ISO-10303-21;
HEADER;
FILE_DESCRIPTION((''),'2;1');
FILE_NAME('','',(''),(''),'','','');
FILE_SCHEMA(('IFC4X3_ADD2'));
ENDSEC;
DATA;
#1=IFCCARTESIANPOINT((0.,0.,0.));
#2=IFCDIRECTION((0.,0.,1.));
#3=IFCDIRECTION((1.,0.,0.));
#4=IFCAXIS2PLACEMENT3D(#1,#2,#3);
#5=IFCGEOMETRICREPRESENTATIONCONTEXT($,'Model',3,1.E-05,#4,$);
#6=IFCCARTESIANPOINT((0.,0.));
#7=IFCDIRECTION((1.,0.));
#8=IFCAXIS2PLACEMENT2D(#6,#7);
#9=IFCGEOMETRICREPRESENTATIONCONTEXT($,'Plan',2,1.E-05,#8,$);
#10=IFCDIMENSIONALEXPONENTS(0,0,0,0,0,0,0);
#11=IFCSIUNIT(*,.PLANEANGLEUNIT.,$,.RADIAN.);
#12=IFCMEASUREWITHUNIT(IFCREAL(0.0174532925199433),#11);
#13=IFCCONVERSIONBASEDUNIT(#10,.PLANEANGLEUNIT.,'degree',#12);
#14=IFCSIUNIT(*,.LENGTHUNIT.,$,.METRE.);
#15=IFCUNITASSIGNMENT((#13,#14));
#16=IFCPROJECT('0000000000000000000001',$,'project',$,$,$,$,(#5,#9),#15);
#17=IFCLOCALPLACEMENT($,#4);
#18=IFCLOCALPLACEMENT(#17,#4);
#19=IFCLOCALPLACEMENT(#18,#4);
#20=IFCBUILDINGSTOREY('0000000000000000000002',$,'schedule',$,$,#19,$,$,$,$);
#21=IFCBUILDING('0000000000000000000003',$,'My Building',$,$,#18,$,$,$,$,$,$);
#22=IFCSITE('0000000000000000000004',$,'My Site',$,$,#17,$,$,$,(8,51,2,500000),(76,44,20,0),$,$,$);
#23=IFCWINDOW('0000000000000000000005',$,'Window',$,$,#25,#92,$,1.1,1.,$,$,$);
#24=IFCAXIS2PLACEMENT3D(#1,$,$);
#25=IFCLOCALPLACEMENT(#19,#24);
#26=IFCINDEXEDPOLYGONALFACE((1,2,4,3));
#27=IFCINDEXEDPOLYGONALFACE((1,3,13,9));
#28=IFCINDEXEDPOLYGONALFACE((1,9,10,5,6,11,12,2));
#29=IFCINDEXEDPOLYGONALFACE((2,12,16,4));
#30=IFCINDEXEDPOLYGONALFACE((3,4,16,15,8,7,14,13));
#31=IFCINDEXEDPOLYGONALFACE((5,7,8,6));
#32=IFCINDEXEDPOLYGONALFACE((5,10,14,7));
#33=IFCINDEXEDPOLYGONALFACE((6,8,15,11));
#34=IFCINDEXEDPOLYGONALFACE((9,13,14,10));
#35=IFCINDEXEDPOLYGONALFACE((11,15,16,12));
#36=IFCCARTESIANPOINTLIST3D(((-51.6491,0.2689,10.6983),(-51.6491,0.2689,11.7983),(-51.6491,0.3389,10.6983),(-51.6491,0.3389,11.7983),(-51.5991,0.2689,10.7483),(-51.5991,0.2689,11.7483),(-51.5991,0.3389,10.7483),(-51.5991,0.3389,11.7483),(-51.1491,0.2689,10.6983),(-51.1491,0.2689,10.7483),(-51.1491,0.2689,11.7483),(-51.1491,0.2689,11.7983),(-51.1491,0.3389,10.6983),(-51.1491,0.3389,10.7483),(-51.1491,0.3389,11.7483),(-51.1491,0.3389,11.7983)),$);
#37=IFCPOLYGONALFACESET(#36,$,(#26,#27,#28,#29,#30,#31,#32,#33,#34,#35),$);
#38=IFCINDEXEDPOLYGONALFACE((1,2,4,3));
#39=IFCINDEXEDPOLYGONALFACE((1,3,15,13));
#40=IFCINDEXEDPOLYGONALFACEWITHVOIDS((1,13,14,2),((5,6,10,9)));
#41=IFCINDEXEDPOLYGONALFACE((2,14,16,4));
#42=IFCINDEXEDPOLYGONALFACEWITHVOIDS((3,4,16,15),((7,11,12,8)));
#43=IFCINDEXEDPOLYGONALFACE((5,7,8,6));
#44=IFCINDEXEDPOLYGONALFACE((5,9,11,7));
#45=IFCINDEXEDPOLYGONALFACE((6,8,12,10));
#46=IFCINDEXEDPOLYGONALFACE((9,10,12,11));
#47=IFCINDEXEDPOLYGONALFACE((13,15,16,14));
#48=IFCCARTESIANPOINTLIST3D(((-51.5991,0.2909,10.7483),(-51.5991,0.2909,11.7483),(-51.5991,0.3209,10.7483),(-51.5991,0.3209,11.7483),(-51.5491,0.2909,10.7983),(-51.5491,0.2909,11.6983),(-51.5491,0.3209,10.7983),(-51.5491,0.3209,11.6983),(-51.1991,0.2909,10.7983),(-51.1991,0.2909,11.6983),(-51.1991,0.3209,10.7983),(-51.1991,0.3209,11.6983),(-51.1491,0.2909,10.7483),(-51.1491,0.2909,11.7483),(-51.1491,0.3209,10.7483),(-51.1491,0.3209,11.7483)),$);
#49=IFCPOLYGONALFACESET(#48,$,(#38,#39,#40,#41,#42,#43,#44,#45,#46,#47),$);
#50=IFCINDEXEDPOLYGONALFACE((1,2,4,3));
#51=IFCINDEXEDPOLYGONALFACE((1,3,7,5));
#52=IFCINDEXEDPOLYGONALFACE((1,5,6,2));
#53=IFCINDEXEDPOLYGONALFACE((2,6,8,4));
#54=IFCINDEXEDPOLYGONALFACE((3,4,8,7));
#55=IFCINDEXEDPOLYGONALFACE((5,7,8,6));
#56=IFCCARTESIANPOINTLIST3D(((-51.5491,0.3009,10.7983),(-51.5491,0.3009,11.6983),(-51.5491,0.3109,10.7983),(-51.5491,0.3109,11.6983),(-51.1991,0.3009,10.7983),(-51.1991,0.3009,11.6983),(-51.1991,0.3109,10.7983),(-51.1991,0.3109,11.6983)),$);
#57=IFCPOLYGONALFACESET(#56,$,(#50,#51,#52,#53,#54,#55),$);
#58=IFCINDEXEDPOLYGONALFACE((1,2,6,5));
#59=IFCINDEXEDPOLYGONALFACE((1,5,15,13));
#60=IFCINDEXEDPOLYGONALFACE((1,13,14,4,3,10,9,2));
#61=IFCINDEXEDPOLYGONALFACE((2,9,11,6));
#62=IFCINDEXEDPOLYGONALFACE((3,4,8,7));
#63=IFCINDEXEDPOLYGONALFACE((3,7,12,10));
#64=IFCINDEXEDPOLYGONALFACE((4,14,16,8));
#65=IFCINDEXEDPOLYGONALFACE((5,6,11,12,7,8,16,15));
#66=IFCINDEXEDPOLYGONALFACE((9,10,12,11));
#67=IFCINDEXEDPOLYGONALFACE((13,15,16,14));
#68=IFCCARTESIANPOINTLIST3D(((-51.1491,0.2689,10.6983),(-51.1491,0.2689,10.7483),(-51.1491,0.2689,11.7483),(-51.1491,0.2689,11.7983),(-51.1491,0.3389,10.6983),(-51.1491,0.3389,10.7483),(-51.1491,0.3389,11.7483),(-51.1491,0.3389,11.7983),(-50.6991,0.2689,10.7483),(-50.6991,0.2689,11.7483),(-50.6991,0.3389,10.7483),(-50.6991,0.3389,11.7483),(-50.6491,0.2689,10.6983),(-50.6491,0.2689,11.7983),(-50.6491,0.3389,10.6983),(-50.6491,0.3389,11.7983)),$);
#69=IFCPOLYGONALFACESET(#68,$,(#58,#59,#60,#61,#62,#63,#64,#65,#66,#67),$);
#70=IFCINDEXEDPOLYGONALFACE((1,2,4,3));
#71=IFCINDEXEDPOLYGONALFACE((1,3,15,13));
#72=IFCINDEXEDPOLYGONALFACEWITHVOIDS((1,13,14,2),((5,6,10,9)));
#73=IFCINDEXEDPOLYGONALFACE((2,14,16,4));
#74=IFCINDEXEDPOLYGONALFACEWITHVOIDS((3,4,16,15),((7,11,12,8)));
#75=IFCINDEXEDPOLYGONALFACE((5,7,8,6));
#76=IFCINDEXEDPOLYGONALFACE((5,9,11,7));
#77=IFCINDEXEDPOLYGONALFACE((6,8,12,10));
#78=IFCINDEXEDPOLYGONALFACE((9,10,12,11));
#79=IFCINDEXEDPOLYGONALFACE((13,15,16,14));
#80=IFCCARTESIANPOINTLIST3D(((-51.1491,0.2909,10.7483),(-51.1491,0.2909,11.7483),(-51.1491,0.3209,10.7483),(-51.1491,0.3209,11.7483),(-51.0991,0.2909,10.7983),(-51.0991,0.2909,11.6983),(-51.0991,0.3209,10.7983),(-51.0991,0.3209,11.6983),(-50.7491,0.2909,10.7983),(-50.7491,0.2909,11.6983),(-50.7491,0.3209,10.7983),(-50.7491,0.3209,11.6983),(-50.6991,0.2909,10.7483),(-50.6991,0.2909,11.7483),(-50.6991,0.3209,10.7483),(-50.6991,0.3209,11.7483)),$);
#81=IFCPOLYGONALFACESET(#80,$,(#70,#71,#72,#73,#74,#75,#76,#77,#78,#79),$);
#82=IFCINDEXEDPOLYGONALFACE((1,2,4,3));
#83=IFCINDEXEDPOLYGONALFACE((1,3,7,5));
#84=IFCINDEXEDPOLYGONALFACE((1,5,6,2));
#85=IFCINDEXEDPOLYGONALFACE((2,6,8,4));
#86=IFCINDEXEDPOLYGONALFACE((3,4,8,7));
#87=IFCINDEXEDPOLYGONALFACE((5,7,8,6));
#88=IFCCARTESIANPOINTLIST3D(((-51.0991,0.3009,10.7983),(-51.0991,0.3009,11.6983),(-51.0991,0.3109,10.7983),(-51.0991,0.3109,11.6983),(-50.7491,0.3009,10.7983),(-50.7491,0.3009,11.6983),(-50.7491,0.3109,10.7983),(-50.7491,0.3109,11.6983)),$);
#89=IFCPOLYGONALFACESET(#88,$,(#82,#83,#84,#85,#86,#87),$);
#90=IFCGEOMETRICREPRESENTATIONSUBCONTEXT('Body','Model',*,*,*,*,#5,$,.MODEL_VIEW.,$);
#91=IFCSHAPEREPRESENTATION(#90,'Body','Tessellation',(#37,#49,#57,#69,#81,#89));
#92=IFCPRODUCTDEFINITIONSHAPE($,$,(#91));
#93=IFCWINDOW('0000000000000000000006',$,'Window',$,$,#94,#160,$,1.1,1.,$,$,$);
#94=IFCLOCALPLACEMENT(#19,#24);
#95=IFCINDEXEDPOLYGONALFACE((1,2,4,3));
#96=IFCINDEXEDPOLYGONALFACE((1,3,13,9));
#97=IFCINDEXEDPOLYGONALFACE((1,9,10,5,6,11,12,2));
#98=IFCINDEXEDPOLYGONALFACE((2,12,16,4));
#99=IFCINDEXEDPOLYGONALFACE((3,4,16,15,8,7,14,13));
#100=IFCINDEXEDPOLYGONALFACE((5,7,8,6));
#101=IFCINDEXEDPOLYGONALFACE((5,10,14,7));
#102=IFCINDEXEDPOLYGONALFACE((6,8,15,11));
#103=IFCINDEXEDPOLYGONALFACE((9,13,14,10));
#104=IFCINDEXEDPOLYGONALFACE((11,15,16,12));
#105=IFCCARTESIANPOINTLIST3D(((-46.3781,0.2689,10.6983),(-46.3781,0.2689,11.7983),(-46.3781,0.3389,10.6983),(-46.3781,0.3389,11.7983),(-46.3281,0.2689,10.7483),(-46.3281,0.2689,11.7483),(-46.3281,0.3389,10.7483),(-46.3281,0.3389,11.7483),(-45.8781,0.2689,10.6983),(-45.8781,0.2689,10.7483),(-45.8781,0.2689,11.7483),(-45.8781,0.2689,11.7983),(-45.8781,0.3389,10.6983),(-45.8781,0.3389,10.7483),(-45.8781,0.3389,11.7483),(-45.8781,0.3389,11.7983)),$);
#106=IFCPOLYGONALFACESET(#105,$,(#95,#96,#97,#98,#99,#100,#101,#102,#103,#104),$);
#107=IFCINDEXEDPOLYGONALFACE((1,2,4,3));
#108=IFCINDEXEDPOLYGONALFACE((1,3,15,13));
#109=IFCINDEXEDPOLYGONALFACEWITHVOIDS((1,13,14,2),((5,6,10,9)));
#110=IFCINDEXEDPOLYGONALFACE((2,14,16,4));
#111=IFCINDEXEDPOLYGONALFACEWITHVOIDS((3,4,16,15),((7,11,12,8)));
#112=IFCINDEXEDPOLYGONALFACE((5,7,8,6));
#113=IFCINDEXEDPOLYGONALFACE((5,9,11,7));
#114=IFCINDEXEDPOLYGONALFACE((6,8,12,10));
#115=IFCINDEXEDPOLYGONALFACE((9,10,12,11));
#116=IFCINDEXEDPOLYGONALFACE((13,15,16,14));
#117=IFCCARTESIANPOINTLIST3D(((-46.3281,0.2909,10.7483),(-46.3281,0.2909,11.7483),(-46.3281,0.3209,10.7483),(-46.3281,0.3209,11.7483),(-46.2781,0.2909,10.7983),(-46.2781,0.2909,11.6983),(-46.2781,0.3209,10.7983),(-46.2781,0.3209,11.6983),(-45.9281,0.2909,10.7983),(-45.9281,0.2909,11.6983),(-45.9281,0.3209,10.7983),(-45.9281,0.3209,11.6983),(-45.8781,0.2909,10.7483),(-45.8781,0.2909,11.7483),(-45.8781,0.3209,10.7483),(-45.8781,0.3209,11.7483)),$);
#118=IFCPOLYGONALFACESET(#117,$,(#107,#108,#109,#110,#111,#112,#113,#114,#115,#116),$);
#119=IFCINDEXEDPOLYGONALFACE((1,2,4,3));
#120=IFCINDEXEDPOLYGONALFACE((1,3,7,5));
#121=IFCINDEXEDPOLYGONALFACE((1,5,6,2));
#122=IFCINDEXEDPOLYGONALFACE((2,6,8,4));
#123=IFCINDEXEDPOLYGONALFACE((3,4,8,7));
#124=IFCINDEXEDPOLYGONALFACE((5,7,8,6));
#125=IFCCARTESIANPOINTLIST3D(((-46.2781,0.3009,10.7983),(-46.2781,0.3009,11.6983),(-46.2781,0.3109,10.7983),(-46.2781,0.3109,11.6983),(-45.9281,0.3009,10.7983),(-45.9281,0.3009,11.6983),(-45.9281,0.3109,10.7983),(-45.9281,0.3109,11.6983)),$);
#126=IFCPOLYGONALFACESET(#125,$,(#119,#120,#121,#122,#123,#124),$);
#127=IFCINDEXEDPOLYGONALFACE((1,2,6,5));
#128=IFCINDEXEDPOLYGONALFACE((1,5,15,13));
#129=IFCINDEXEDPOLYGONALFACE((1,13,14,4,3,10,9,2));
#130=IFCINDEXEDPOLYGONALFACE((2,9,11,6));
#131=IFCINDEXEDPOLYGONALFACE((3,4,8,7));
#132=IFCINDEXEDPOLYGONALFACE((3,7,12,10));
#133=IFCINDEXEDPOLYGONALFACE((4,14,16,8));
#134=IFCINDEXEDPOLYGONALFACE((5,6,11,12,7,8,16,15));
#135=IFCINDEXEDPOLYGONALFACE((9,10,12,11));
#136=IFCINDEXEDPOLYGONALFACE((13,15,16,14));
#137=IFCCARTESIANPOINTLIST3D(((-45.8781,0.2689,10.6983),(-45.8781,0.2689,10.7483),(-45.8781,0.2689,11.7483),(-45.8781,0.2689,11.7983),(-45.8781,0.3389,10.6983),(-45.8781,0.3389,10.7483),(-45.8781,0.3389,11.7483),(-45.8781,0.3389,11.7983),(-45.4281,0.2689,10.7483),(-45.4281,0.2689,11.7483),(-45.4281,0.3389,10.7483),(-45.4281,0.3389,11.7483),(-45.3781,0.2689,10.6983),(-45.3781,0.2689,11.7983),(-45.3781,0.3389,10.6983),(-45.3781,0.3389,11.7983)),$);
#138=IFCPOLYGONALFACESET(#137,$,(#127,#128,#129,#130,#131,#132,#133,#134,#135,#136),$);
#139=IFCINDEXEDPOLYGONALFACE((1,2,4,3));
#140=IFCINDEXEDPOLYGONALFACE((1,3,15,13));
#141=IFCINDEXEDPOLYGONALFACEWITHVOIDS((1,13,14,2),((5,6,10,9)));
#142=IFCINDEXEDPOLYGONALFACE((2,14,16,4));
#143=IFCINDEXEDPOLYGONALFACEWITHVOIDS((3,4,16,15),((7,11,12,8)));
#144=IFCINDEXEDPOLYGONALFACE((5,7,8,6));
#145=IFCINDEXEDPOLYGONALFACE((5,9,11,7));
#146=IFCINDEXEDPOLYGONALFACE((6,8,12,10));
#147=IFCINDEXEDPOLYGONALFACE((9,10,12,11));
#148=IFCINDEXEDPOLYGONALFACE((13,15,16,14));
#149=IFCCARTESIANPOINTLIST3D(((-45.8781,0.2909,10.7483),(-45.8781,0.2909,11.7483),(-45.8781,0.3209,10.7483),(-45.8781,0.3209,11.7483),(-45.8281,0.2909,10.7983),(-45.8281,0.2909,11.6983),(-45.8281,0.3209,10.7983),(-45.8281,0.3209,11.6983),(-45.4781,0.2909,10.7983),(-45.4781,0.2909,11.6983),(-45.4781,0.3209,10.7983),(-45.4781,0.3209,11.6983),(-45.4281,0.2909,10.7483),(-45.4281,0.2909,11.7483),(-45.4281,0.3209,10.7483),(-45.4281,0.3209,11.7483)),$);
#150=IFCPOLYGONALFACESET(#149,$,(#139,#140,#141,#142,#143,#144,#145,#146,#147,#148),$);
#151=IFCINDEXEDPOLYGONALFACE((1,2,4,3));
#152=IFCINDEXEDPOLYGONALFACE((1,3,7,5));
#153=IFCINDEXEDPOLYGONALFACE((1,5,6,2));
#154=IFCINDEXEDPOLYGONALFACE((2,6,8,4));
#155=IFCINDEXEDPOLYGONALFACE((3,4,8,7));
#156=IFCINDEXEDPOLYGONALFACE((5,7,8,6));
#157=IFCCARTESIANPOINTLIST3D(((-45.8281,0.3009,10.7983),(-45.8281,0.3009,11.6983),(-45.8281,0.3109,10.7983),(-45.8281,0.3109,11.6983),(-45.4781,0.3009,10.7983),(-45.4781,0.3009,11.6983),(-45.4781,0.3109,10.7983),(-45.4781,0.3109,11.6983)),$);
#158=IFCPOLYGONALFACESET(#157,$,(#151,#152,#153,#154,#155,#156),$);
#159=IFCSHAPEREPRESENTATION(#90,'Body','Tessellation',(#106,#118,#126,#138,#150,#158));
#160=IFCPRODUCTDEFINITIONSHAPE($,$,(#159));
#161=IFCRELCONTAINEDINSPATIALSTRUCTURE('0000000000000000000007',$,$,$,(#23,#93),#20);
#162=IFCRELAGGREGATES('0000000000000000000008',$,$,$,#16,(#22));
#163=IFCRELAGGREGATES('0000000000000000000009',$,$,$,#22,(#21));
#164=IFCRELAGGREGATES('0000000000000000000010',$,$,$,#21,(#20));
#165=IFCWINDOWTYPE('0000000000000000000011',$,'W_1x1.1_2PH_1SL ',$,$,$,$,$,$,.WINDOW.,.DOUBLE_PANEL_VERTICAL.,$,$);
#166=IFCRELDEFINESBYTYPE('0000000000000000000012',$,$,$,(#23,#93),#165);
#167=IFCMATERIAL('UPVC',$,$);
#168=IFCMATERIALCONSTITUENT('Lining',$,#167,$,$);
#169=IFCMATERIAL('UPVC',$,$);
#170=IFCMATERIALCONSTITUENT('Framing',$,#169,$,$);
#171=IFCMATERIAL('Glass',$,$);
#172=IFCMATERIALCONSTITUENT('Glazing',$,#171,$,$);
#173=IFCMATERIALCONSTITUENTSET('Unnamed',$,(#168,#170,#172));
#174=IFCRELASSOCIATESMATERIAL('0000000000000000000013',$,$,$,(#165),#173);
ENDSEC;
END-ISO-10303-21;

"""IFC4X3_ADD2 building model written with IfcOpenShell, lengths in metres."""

from ifc_helpers import new_model, entity, si_unit, converted_unit, frame, origin_with_axes, origin_2d_with_axis, place, context, subcontext, project, spatial, line, indexed_curve, outline, extrude, shape, source, transform, mapped, material, constituent, constituent_set, type_object, type_shapes, element, save


model = new_model("IFC4X3_ADD2")

# Units and contexts
model_context = context("Model", 3, precision=1e-05, world=origin_with_axes())
plan_context = context("Plan", 2, precision=1e-05, world=origin_2d_with_axis())
body_context_1 = subcontext(model_context, "Body", "Model", "MODEL_VIEW")
body_context_2 = subcontext(plan_context, "Body", "Plan", "PLAN_VIEW")
ifc_project = project(units=[converted_unit("PLANEANGLEUNIT", "degree", entity("IfcReal", 0.0174532925199433), si_unit("PLANEANGLEUNIT", "RADIAN"), dimensions=[0, 0, 0, 0, 0, 0, 0]), si_unit("LENGTHUNIT", "METRE")], contexts=[model_context, plan_context])

# Site, building, storey
site_placement = place(None, origin_with_axes())
site = spatial("IfcSite", under=ifc_project, at=site_placement, Name="My Site", RefLatitude=(8, 51, 2, 500000), RefLongitude=(76, 44, 20, 0))
building_placement = place(site_placement, origin_with_axes())
building = spatial("IfcBuilding", under=site, at=building_placement, Name="My Building")
storey_placement = place(building_placement, origin_with_axes())
storey = spatial("IfcBuildingStorey", under=building, at=storey_placement, Name="schedule")

# Windows
ifc_material_1 = material(Name="UPVC")
ifc_material_2 = material(Name="UPVC")
ifc_material_3 = material(Name="Glass")
placement_1 = place(storey_placement, frame((-67.8485, 0.2689, 3.1152), z_axis=(0.0, 0.0, 1.0), x_axis=(1.0, 0.0, 0.0)))
ifc_constituent_1 = constituent(ifc_material_1, Name="Lining")
ifc_constituent_2 = constituent(ifc_material_2, Name="Framing")
ifc_constituent_3 = constituent(ifc_material_3, Name="Glazing")
ifc_constituent_set_1 = constituent_set(constituents=[ifc_constituent_1, ifc_constituent_2, ifc_constituent_3], Name="Unnamed")
window_type_1 = type_object("IfcWindowType", Name="W_1x1.1_2PH_1SL ", PartitioningType="DOUBLE_PANEL_VERTICAL", PredefinedType="WINDOW", material=ifc_constituent_set_1)
shared_shape_1 = source(origin_with_axes(), body_context_1, "Body", "SweptSolid", [
    extrude(outline(indexed_curve([(0.5, 0.0), (0.0, 0.0), (0.0, 1.1), (0.5, 1.1), (0.5, 1.05), (0.05, 1.05), (0.05, 0.05), (0.5, 0.05)], segments=[line(1, 2, 3, 4, 5, 6, 7, 8, 1)])), frame((0.0, 0.0, 0.0), z_axis=(0.0, -1.0, 0.0), x_axis=(1.0, 0.0, 0.0)), (0.0, 0.0, -1.0), 0.07),
    extrude(outline(indexed_curve([(0.0, 0.0), (0.45, 0.0), (0.45, 1.0), (0.0, 1.0)], segments=[line(1, 2, 3, 4, 1)]), holes=[indexed_curve([(0.05, 0.05), (0.4, 0.05), (0.4, 0.95), (0.05, 0.95)], segments=[line(1, 2, 3, 4, 1)])]), frame((0.05, 0.022, 0.05), z_axis=(0.0, -1.0, 0.0), x_axis=(1.0, 0.0, 0.0)), (0.0, 0.0, -1.0), 0.03),
    extrude(outline(indexed_curve([(0.05, 0.05), (0.4, 0.05), (0.4, 0.95), (0.05, 0.95)], segments=[line(1, 2, 3, 4, 1)])), frame((0.05, 0.032, 0.05), z_axis=(0.0, -1.0, 0.0), x_axis=(1.0, 0.0, 0.0)), (0.0, 0.0, -1.0), 0.01),
    extrude(outline(indexed_curve([(0.0, 1.1), (0.5, 1.1), (0.5, 0.0), (0.0, 0.0), (0.0, 0.05), (0.45, 0.05), (0.45, 1.05), (0.0, 1.05)], segments=[line(1, 2, 3, 4, 5, 6, 7, 8, 1)])), frame((0.5, 0.0, 0.0), z_axis=(0.0, -1.0, 0.0), x_axis=(1.0, 0.0, 0.0)), (0.0, 0.0, -1.0), 0.07),
    extrude(outline(indexed_curve([(0.0, 0.0), (0.45, 0.0), (0.45, 1.0), (0.0, 1.0)], segments=[line(1, 2, 3, 4, 1)]), holes=[indexed_curve([(0.05, 0.05), (0.4, 0.05), (0.4, 0.95), (0.05, 0.95)], segments=[line(1, 2, 3, 4, 1)])]), frame((0.5, 0.022, 0.05), z_axis=(0.0, -1.0, 0.0), x_axis=(1.0, 0.0, 0.0)), (0.0, 0.0, -1.0), 0.03),
    extrude(outline(indexed_curve([(0.05, 0.05), (0.4, 0.05), (0.4, 0.95), (0.05, 0.95)], segments=[line(1, 2, 3, 4, 1)])), frame((0.5, 0.032, 0.05), z_axis=(0.0, -1.0, 0.0), x_axis=(1.0, 0.0, 0.0)), (0.0, 0.0, -1.0), 0.01),
])
shared_shape_2 = source(origin_with_axes(), body_context_2, "Body", "Curve2D", [
    entity("IfcIndexedPolyCurve", entity("IfcCartesianPointList2D", [[0.05, 0.0], [0.5, 0.0]])),
    entity("IfcIndexedPolyCurve", entity("IfcCartesianPointList2D", [[0.0, 0.07], [0.05, 0.07], [0.05, 0.0], [0.0, 0.0]]), [entity("IfcLineIndex", [1, 2, 3, 4, 1])]),
    entity("IfcIndexedPolyCurve", entity("IfcCartesianPointList2D", [[0.5, 0.07], [0.5, 0.07], [0.5, 0.0], [0.5, 0.0]])),
    entity("IfcIndexedPolyCurve", entity("IfcCartesianPointList2D", [[0.05, 0.022], [0.1, 0.022], [0.1, 0.052], [0.05, 0.052]]), [entity("IfcLineIndex", [1, 2, 3, 4, 1])]),
    entity("IfcIndexedPolyCurve", entity("IfcCartesianPointList2D", [[0.5, 0.022], [0.45, 0.022], [0.45, 0.052], [0.5, 0.052]]), [entity("IfcLineIndex", [1, 2, 3, 4, 1])]),
    entity("IfcIndexedPolyCurve", entity("IfcCartesianPointList2D", [[0.1, 0.022], [0.45, 0.022]])),
    entity("IfcIndexedPolyCurve", entity("IfcCartesianPointList2D", [[0.1, 0.052], [0.45, 0.052]])),
    entity("IfcIndexedPolyCurve", entity("IfcCartesianPointList2D", [[0.1, 0.037], [0.45, 0.037]])),
    entity("IfcIndexedPolyCurve", entity("IfcCartesianPointList2D", [[0.5, 0.0], [0.95, 0.0]])),
    entity("IfcIndexedPolyCurve", entity("IfcCartesianPointList2D", [[0.5, 0.07], [0.5, 0.07], [0.5, 0.0], [0.5, 0.0]])),
    entity("IfcIndexedPolyCurve", entity("IfcCartesianPointList2D", [[1.0, 0.07], [0.95, 0.07], [0.95, 0.0], [1.0, 0.0]]), [entity("IfcLineIndex", [1, 2, 3, 4, 1])]),
    entity("IfcIndexedPolyCurve", entity("IfcCartesianPointList2D", [[0.5, 0.022], [0.55, 0.022], [0.55, 0.052], [0.5, 0.052]]), [entity("IfcLineIndex", [1, 2, 3, 4, 1])]),
    entity("IfcIndexedPolyCurve", entity("IfcCartesianPointList2D", [[0.95, 0.022], [0.9, 0.022], [0.9, 0.052], [0.95, 0.052]]), [entity("IfcLineIndex", [1, 2, 3, 4, 1])]),
    entity("IfcIndexedPolyCurve", entity("IfcCartesianPointList2D", [[0.55, 0.022], [0.9, 0.022]])),
    entity("IfcIndexedPolyCurve", entity("IfcCartesianPointList2D", [[0.55, 0.052], [0.9, 0.052]])),
    entity("IfcIndexedPolyCurve", entity("IfcCartesianPointList2D", [[0.55, 0.037], [0.9, 0.037]])),
])
type_shapes(window_type_1, [shared_shape_1, shared_shape_2])
placement_2 = place(placement_1, frame((16.1995, 0.0, 7.5831), z_axis=(0.0, 0.0, 1.0), x_axis=(1.0, 0.0, 0.0)))
window_1_placement = place(placement_2, origin_with_axes())
element("IfcWindow", 1, at=window_1_placement, inside=storey, type_object=window_type_1, Name="Window", OverallHeight=1.1, OverallWidth=1.0, shapes=[
    shape(body_context_1, "Body", "MappedRepresentation", [mapped(shared_shape_1, transform((0.0, 0.0, 0.0), x_axis=(1.0, 0.0, 0.0), y_axis=(0.0, 1.0, 0.0), z_axis=(0.0, 0.0, 1.0), scale=1.0))]),
    shape(body_context_2, "Body", "MappedRepresentation", [mapped(shared_shape_2, transform((0.0, 0.0, 0.0), x_axis=(1.0, 0.0, 0.0), y_axis=(0.0, 1.0, 0.0), z_axis=(0.0, 0.0, 1.0), scale=1.0))]),
])
placement_3 = place(placement_1, frame((21.4704, 0.0, 7.5831), z_axis=(0.0, 0.0, 1.0), x_axis=(1.0, 0.0, 0.0)))
window_2_placement = place(placement_3, origin_with_axes())
element("IfcWindow", 2, at=window_2_placement, inside=storey, type_object=window_type_1, Name="Window", OverallHeight=1.1, OverallWidth=1.0, shapes=[
    shape(body_context_1, "Body", "MappedRepresentation", [mapped(shared_shape_1, transform((0.0, 0.0, 0.0), x_axis=(1.0, 0.0, 0.0), y_axis=(0.0, 1.0, 0.0), z_axis=(0.0, 0.0, 1.0), scale=1.0))]),
    shape(body_context_2, "Body", "MappedRepresentation", [mapped(shared_shape_2, transform((0.0, 0.0, 0.0), x_axis=(1.0, 0.0, 0.0), y_axis=(0.0, 1.0, 0.0), z_axis=(0.0, 0.0, 1.0), scale=1.0))]),
])

save(model, "model.ifc")
